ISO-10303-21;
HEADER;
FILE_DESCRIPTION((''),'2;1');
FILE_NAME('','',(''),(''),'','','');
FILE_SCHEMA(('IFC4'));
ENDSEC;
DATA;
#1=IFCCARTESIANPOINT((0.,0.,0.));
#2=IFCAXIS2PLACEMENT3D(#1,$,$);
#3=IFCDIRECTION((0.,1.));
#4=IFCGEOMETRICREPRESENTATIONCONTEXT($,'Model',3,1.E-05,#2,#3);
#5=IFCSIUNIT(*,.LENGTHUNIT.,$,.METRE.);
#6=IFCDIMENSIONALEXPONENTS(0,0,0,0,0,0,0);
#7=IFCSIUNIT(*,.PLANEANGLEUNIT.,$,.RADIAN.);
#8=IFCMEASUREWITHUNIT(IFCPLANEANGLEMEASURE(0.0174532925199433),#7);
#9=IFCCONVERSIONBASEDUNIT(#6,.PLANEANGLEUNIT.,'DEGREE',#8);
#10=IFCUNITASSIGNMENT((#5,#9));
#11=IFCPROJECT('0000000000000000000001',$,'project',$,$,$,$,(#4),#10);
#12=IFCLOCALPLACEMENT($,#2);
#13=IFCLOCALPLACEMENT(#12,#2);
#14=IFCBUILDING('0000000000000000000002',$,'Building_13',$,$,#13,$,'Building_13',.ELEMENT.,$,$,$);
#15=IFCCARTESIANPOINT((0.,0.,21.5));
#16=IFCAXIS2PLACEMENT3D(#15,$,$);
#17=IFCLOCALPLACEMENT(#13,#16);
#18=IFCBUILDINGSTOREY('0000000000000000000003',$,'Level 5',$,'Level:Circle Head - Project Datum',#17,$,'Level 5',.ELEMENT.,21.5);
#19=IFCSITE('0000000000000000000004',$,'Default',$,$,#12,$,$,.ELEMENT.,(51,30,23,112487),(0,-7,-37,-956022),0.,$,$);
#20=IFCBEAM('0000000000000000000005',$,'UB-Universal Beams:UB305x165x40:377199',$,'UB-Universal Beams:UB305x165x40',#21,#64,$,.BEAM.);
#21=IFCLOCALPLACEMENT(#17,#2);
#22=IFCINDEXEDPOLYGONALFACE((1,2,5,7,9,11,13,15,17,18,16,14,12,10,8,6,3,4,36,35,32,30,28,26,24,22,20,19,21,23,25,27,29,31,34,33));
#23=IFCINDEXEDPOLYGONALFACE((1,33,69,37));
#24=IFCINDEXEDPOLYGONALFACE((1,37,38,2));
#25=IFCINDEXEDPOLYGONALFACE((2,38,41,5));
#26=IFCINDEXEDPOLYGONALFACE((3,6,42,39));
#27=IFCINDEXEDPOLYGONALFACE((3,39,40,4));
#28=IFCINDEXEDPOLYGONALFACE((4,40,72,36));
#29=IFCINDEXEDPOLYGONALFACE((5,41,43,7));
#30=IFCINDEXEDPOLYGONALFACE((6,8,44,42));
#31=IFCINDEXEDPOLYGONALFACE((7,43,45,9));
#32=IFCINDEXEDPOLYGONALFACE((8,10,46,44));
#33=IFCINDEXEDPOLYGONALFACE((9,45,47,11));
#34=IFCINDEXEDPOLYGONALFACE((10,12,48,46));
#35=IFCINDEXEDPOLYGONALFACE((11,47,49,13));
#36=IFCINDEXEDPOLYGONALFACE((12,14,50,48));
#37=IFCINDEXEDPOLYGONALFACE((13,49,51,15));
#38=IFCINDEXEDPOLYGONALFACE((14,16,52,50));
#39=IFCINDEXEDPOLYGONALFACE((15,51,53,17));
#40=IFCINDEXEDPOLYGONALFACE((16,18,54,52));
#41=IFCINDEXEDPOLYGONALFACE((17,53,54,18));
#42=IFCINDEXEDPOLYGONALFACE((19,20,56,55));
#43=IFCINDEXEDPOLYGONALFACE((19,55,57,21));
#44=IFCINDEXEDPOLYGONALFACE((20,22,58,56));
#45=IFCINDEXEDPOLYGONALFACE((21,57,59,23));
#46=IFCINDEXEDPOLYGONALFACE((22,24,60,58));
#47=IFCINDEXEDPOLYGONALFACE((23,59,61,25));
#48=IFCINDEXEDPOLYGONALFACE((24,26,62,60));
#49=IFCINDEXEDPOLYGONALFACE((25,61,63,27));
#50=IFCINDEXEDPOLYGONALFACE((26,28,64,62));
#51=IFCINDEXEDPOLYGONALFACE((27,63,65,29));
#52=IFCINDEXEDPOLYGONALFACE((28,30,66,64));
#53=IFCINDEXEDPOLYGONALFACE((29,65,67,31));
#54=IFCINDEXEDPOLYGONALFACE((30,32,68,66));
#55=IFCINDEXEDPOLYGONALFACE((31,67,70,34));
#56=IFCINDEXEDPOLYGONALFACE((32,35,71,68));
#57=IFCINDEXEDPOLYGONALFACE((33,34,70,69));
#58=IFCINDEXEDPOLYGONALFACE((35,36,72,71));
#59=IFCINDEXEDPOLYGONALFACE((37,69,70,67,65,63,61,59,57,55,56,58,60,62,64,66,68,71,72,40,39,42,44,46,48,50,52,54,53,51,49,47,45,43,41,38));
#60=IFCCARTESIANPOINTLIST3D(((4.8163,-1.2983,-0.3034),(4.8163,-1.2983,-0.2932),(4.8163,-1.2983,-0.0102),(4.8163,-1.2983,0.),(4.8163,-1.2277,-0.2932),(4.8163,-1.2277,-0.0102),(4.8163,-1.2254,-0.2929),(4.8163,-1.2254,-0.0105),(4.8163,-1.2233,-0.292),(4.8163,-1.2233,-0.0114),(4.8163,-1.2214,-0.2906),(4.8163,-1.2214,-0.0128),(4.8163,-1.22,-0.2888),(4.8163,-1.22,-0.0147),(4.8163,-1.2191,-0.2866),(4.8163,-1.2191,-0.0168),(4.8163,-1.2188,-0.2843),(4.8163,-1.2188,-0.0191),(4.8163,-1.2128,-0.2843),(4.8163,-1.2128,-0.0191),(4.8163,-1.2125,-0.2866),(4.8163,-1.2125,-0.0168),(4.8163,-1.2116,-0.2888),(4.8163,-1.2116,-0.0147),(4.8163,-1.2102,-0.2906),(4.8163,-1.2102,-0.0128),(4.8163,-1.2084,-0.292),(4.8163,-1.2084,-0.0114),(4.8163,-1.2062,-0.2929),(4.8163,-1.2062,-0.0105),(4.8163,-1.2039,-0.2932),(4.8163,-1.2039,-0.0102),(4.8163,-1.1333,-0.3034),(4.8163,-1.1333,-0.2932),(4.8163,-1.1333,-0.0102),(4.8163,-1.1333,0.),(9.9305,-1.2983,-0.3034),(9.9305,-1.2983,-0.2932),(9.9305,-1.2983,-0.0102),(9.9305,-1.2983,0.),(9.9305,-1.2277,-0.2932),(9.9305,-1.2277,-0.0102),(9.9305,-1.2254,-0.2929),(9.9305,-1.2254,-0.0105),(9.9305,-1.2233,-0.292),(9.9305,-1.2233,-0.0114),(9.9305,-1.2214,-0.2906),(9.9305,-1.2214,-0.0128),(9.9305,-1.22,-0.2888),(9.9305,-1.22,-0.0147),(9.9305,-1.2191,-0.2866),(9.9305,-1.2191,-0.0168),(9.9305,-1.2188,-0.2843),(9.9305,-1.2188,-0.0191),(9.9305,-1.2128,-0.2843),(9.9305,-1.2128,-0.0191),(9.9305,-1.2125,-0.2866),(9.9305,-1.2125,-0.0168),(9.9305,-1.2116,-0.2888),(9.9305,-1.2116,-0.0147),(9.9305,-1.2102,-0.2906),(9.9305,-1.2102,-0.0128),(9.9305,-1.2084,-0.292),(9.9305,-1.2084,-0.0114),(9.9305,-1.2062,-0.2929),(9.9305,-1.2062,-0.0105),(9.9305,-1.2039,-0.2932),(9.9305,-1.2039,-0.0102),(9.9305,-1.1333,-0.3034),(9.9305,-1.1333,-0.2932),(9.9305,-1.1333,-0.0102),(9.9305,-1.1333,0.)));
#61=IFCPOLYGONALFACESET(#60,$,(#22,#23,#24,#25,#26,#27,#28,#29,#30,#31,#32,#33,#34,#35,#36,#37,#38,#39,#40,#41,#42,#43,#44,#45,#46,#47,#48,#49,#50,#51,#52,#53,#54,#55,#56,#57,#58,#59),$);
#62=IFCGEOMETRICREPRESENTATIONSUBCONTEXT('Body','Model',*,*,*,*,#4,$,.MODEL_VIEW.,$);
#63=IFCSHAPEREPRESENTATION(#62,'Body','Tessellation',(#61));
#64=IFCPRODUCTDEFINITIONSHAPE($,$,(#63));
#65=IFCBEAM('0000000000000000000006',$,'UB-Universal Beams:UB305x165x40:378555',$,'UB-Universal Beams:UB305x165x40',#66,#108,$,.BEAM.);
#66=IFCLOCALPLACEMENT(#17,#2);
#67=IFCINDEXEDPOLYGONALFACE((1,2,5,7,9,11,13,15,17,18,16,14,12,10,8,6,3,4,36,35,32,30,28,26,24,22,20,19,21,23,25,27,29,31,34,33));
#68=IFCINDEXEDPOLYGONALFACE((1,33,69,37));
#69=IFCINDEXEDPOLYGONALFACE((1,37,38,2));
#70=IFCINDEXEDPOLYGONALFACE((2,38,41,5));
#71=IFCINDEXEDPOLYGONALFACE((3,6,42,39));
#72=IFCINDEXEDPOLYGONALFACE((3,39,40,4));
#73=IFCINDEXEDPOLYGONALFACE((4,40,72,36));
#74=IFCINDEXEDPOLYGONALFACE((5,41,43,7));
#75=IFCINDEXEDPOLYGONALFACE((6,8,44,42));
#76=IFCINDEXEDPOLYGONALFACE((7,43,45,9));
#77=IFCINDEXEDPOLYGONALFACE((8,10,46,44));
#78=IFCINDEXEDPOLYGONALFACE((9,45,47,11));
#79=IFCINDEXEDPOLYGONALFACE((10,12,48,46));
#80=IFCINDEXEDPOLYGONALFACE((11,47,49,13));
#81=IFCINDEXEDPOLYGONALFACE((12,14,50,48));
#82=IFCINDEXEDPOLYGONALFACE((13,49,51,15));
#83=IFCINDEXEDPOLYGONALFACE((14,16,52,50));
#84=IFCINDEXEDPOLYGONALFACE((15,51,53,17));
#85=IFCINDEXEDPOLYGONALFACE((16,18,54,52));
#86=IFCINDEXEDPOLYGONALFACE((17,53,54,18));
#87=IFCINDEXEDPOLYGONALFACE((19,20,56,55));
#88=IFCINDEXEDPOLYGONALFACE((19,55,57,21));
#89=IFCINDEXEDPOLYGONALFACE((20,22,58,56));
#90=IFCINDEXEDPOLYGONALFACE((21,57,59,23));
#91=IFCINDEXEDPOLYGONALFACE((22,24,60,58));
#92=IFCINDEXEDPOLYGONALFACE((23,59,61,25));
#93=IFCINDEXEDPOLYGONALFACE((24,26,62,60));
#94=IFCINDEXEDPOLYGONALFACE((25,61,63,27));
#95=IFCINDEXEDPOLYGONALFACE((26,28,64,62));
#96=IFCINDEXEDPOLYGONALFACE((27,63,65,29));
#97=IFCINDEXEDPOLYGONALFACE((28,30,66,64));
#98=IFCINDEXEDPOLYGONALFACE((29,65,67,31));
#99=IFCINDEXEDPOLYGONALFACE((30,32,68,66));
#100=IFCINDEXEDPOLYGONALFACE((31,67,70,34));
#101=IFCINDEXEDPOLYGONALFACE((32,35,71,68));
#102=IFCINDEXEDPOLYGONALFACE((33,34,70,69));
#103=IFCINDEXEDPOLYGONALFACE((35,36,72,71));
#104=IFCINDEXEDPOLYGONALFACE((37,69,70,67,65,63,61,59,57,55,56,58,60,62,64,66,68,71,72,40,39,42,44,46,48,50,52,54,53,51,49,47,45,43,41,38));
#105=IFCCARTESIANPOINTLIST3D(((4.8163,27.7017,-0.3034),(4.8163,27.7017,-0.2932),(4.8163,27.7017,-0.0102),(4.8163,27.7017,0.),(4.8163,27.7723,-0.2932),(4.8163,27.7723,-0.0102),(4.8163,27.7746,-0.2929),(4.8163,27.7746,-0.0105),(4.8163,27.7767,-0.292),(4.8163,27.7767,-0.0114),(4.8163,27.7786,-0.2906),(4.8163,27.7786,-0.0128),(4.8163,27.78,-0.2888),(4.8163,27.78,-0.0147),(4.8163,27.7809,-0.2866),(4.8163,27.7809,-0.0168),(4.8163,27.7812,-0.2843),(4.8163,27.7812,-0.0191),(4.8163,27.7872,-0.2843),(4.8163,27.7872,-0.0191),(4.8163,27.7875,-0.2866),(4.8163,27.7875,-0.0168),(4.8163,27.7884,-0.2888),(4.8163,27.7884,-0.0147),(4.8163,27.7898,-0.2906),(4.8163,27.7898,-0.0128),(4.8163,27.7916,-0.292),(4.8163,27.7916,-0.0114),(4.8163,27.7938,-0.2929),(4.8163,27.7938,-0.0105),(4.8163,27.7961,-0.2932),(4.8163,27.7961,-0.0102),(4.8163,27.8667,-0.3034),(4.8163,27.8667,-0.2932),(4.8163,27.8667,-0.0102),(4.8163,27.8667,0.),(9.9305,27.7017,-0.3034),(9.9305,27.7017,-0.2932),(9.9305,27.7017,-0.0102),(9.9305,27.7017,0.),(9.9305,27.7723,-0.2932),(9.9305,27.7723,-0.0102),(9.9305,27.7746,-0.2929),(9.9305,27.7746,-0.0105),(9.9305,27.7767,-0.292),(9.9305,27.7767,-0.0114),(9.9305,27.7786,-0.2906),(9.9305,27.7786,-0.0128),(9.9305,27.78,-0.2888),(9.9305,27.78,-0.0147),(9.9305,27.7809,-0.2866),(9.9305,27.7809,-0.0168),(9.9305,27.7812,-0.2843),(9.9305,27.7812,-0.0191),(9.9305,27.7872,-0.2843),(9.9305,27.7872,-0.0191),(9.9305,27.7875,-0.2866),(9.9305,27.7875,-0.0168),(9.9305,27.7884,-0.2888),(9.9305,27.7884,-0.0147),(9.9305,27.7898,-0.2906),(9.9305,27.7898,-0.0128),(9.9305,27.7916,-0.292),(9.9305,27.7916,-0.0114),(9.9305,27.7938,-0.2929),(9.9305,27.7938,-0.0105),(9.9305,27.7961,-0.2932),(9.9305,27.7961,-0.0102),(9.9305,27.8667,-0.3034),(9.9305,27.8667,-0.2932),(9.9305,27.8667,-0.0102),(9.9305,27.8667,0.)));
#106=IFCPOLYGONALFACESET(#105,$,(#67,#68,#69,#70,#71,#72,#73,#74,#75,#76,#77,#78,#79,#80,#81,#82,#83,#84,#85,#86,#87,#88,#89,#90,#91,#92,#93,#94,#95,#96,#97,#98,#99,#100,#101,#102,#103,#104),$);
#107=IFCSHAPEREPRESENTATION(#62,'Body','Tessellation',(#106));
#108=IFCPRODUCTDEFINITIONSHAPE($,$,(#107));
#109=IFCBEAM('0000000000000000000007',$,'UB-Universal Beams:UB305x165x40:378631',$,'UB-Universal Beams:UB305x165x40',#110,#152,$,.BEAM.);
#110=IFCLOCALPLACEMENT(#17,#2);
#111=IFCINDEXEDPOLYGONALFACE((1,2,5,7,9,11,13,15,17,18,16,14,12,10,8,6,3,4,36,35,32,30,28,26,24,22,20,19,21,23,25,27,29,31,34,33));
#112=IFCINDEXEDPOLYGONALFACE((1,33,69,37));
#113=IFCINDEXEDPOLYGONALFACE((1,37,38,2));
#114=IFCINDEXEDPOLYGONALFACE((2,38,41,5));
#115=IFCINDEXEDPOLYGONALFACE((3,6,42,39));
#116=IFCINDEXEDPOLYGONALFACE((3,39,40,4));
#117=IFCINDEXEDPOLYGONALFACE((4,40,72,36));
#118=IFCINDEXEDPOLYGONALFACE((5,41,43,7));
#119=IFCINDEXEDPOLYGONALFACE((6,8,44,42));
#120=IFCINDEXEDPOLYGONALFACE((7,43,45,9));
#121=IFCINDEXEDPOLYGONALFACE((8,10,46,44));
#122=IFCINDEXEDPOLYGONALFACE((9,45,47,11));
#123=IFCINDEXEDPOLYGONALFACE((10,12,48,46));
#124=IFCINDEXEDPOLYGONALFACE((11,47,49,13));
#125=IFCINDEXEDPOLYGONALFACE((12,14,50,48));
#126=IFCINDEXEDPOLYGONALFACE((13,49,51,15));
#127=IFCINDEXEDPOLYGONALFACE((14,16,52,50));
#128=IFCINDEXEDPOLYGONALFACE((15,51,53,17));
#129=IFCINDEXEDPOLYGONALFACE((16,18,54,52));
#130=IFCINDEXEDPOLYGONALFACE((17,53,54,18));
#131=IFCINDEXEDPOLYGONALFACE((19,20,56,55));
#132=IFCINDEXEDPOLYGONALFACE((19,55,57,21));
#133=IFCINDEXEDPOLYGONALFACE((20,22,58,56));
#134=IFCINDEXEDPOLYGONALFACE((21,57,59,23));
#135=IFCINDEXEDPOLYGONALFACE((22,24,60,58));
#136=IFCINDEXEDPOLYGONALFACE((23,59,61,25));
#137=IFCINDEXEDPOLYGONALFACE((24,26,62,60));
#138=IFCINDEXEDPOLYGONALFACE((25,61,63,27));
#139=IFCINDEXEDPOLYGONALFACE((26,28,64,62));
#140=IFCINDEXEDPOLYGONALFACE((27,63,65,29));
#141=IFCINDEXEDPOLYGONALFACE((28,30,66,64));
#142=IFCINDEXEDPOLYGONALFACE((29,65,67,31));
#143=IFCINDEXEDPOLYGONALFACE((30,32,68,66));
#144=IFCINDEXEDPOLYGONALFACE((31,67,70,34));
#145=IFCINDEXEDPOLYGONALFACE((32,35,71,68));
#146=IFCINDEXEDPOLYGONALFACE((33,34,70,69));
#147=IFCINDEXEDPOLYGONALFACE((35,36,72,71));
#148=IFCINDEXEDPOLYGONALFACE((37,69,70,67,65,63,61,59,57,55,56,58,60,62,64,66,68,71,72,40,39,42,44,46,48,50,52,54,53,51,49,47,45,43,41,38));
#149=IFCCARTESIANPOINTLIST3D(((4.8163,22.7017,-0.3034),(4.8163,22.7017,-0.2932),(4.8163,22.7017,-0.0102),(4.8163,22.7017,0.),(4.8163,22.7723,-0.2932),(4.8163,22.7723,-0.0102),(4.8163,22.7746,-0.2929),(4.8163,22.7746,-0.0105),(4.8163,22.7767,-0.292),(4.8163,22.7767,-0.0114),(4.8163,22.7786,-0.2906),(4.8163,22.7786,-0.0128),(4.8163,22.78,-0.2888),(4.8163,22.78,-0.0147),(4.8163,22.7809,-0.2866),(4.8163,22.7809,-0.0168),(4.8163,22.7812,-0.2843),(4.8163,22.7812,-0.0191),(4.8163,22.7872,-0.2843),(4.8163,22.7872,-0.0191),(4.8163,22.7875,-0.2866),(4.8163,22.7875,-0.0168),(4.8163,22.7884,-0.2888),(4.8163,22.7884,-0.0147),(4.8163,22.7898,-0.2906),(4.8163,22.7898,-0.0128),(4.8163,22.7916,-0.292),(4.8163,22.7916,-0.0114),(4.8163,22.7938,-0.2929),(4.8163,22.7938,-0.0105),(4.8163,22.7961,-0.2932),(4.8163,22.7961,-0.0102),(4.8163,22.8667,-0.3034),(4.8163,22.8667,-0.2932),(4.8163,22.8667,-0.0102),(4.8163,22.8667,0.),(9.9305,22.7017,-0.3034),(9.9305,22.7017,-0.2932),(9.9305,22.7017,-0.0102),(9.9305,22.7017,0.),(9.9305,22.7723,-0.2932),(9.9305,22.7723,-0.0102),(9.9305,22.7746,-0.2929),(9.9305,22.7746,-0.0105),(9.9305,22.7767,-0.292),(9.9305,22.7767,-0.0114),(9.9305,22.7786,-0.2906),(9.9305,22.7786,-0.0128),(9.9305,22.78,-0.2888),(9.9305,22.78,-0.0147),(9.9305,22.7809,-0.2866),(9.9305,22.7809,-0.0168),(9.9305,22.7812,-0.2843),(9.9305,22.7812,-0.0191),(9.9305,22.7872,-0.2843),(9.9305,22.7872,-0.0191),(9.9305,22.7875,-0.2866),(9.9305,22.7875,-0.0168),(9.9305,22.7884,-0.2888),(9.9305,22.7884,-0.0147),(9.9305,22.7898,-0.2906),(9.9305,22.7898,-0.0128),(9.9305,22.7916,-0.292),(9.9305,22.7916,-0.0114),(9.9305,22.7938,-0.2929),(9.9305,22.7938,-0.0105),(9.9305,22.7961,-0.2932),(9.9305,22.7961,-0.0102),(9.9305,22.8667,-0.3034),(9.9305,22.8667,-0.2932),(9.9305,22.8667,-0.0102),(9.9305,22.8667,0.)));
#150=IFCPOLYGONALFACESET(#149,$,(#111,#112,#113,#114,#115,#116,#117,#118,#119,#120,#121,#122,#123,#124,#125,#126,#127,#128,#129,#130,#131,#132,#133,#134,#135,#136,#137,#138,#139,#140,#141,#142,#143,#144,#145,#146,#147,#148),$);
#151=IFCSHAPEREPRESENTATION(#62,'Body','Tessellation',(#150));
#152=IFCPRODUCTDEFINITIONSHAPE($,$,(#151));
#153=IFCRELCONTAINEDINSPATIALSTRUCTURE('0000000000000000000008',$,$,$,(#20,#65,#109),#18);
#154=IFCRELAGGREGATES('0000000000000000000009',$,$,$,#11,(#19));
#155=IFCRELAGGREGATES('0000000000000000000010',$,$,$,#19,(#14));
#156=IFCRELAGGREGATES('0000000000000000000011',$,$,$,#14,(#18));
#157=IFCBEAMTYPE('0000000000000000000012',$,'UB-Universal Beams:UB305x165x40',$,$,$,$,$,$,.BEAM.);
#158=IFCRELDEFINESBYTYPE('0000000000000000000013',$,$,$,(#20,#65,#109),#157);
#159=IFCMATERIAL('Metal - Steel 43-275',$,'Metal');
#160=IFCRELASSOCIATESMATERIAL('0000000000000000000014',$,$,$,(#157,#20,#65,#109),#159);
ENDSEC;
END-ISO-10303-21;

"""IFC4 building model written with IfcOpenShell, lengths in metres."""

from ifc_helpers import new_model, entity, si_unit, converted_unit, direction, frame, origin, place, context, subcontext, project, spatial, line, arc, indexed_curve, outline, extrude, source, transform, mapped, material, type_object, type_shapes, element, save


model = new_model("IFC4")

# Units and contexts
model_context = context("Model", 3, precision=1e-05, world=origin(), true_north=direction((0.0, 1.0)))
body_context = subcontext(model_context, "Body", "Model", "MODEL_VIEW")
ifc_project = project(units=[si_unit("LENGTHUNIT", "METRE"), converted_unit("PLANEANGLEUNIT", "DEGREE", entity("IfcPlaneAngleMeasure", 0.0174532925199433), si_unit("PLANEANGLEUNIT", "RADIAN"), dimensions=[0, 0, 0, 0, 0, 0, 0])], contexts=[model_context])

# Site, building, storey
site_placement = place(None, origin())
site = spatial("IfcSite", under=ifc_project, at=site_placement, Name="Default", CompositionType="ELEMENT", RefLatitude=(51, 30, 23, 112487), RefLongitude=(0, -7, -37, -956022), RefElevation=0.0)
building_placement = place(site_placement, origin())
building = spatial("IfcBuilding", under=site, at=building_placement, Name="Building_13", LongName="Building_13", CompositionType="ELEMENT")
storey_placement = place(building_placement, frame((0.0, 0.0, 21.5)))
storey = spatial("IfcBuildingStorey", under=building, at=storey_placement, Name="Level 5", ObjectType="Level:Circle Head - Project Datum", LongName="Level 5", CompositionType="ELEMENT", Elevation=21.5)

# Beams
ifc_material = material(Name="Metal - Steel 43-275", Category="Metal")
beam_type_1 = type_object("IfcBeamType", Name="UB-Universal Beams:UB305x165x40", PredefinedType="BEAM", material=ifc_material)
shared_shape_1 = source(origin(), body_context, "Body", "SweptSolid", [
    extrude(outline(indexed_curve([(-0.0825, -0.1415), (-0.0825, -0.1517), (0.0825, -0.1517), (0.0825, -0.1415), (0.0119, -0.1415), (0.0056, -0.1389), (0.003, -0.1326), (0.003, 0.1326), (0.0056, 0.1389), (0.0119, 0.1415), (0.0825, 0.1415), (0.0825, 0.1517), (-0.0825, 0.1517), (-0.0825, 0.1415), (-0.0119, 0.1415), (-0.0056, 0.1389), (-0.003, 0.1326), (-0.003, -0.1326), (-0.0056, -0.1389), (-0.0119, -0.1415)], segments=[line(1, 2, 3, 4, 5), arc(5, 6, 7), line(7, 8), arc(8, 9, 10), line(10, 11, 12, 13, 14, 15), arc(15, 16, 17), line(17, 18), arc(18, 19, 20), line(20, 1)], self_intersect=False)), frame((-2.5571, 0.0, 0.0), z_axis=(-1.0, 0.0, 0.0), x_axis=(0.0, -1.0, 0.0)), (0.0, 0.0, -1.0), 5.1142),
])
type_shapes(beam_type_1, [shared_shape_1])
beam_1_placement = place(storey_placement, frame((7.3734, -1.2158, -0.1517), z_axis=(0.0, 0.0, 1.0), x_axis=(-1.0, 0.0, 0.0)))
element("IfcBeam", 1, at=beam_1_placement, inside=storey, type_object=beam_type_1, material=ifc_material, Name="UB-Universal Beams:UB305x165x40:377199", ObjectType="UB-Universal Beams:UB305x165x40", PredefinedType="BEAM", context=body_context, shape_type="MappedRepresentation", body=[
    mapped(shared_shape_1, transform((0.0, 0.0, 0.0), scale=1.0)),
])
for number, where, name in (
    (2, (7.3734, 27.7842, -0.1517), "UB-Universal Beams:UB305x165x40:378555"),
    (3, (7.3734, 22.7842, -0.1517), "UB-Universal Beams:UB305x165x40:378631"),
):
    element("IfcBeam", number, at=place(storey_placement, frame(where)), inside=storey, type_object=beam_type_1, material=ifc_material, Name=name, ObjectType="UB-Universal Beams:UB305x165x40", PredefinedType="BEAM", context=body_context, shape_type="MappedRepresentation", body=[
        mapped(shared_shape_1, transform((0.0, 0.0, 0.0), scale=1.0)),
    ])

save(model, "model.ifc")
